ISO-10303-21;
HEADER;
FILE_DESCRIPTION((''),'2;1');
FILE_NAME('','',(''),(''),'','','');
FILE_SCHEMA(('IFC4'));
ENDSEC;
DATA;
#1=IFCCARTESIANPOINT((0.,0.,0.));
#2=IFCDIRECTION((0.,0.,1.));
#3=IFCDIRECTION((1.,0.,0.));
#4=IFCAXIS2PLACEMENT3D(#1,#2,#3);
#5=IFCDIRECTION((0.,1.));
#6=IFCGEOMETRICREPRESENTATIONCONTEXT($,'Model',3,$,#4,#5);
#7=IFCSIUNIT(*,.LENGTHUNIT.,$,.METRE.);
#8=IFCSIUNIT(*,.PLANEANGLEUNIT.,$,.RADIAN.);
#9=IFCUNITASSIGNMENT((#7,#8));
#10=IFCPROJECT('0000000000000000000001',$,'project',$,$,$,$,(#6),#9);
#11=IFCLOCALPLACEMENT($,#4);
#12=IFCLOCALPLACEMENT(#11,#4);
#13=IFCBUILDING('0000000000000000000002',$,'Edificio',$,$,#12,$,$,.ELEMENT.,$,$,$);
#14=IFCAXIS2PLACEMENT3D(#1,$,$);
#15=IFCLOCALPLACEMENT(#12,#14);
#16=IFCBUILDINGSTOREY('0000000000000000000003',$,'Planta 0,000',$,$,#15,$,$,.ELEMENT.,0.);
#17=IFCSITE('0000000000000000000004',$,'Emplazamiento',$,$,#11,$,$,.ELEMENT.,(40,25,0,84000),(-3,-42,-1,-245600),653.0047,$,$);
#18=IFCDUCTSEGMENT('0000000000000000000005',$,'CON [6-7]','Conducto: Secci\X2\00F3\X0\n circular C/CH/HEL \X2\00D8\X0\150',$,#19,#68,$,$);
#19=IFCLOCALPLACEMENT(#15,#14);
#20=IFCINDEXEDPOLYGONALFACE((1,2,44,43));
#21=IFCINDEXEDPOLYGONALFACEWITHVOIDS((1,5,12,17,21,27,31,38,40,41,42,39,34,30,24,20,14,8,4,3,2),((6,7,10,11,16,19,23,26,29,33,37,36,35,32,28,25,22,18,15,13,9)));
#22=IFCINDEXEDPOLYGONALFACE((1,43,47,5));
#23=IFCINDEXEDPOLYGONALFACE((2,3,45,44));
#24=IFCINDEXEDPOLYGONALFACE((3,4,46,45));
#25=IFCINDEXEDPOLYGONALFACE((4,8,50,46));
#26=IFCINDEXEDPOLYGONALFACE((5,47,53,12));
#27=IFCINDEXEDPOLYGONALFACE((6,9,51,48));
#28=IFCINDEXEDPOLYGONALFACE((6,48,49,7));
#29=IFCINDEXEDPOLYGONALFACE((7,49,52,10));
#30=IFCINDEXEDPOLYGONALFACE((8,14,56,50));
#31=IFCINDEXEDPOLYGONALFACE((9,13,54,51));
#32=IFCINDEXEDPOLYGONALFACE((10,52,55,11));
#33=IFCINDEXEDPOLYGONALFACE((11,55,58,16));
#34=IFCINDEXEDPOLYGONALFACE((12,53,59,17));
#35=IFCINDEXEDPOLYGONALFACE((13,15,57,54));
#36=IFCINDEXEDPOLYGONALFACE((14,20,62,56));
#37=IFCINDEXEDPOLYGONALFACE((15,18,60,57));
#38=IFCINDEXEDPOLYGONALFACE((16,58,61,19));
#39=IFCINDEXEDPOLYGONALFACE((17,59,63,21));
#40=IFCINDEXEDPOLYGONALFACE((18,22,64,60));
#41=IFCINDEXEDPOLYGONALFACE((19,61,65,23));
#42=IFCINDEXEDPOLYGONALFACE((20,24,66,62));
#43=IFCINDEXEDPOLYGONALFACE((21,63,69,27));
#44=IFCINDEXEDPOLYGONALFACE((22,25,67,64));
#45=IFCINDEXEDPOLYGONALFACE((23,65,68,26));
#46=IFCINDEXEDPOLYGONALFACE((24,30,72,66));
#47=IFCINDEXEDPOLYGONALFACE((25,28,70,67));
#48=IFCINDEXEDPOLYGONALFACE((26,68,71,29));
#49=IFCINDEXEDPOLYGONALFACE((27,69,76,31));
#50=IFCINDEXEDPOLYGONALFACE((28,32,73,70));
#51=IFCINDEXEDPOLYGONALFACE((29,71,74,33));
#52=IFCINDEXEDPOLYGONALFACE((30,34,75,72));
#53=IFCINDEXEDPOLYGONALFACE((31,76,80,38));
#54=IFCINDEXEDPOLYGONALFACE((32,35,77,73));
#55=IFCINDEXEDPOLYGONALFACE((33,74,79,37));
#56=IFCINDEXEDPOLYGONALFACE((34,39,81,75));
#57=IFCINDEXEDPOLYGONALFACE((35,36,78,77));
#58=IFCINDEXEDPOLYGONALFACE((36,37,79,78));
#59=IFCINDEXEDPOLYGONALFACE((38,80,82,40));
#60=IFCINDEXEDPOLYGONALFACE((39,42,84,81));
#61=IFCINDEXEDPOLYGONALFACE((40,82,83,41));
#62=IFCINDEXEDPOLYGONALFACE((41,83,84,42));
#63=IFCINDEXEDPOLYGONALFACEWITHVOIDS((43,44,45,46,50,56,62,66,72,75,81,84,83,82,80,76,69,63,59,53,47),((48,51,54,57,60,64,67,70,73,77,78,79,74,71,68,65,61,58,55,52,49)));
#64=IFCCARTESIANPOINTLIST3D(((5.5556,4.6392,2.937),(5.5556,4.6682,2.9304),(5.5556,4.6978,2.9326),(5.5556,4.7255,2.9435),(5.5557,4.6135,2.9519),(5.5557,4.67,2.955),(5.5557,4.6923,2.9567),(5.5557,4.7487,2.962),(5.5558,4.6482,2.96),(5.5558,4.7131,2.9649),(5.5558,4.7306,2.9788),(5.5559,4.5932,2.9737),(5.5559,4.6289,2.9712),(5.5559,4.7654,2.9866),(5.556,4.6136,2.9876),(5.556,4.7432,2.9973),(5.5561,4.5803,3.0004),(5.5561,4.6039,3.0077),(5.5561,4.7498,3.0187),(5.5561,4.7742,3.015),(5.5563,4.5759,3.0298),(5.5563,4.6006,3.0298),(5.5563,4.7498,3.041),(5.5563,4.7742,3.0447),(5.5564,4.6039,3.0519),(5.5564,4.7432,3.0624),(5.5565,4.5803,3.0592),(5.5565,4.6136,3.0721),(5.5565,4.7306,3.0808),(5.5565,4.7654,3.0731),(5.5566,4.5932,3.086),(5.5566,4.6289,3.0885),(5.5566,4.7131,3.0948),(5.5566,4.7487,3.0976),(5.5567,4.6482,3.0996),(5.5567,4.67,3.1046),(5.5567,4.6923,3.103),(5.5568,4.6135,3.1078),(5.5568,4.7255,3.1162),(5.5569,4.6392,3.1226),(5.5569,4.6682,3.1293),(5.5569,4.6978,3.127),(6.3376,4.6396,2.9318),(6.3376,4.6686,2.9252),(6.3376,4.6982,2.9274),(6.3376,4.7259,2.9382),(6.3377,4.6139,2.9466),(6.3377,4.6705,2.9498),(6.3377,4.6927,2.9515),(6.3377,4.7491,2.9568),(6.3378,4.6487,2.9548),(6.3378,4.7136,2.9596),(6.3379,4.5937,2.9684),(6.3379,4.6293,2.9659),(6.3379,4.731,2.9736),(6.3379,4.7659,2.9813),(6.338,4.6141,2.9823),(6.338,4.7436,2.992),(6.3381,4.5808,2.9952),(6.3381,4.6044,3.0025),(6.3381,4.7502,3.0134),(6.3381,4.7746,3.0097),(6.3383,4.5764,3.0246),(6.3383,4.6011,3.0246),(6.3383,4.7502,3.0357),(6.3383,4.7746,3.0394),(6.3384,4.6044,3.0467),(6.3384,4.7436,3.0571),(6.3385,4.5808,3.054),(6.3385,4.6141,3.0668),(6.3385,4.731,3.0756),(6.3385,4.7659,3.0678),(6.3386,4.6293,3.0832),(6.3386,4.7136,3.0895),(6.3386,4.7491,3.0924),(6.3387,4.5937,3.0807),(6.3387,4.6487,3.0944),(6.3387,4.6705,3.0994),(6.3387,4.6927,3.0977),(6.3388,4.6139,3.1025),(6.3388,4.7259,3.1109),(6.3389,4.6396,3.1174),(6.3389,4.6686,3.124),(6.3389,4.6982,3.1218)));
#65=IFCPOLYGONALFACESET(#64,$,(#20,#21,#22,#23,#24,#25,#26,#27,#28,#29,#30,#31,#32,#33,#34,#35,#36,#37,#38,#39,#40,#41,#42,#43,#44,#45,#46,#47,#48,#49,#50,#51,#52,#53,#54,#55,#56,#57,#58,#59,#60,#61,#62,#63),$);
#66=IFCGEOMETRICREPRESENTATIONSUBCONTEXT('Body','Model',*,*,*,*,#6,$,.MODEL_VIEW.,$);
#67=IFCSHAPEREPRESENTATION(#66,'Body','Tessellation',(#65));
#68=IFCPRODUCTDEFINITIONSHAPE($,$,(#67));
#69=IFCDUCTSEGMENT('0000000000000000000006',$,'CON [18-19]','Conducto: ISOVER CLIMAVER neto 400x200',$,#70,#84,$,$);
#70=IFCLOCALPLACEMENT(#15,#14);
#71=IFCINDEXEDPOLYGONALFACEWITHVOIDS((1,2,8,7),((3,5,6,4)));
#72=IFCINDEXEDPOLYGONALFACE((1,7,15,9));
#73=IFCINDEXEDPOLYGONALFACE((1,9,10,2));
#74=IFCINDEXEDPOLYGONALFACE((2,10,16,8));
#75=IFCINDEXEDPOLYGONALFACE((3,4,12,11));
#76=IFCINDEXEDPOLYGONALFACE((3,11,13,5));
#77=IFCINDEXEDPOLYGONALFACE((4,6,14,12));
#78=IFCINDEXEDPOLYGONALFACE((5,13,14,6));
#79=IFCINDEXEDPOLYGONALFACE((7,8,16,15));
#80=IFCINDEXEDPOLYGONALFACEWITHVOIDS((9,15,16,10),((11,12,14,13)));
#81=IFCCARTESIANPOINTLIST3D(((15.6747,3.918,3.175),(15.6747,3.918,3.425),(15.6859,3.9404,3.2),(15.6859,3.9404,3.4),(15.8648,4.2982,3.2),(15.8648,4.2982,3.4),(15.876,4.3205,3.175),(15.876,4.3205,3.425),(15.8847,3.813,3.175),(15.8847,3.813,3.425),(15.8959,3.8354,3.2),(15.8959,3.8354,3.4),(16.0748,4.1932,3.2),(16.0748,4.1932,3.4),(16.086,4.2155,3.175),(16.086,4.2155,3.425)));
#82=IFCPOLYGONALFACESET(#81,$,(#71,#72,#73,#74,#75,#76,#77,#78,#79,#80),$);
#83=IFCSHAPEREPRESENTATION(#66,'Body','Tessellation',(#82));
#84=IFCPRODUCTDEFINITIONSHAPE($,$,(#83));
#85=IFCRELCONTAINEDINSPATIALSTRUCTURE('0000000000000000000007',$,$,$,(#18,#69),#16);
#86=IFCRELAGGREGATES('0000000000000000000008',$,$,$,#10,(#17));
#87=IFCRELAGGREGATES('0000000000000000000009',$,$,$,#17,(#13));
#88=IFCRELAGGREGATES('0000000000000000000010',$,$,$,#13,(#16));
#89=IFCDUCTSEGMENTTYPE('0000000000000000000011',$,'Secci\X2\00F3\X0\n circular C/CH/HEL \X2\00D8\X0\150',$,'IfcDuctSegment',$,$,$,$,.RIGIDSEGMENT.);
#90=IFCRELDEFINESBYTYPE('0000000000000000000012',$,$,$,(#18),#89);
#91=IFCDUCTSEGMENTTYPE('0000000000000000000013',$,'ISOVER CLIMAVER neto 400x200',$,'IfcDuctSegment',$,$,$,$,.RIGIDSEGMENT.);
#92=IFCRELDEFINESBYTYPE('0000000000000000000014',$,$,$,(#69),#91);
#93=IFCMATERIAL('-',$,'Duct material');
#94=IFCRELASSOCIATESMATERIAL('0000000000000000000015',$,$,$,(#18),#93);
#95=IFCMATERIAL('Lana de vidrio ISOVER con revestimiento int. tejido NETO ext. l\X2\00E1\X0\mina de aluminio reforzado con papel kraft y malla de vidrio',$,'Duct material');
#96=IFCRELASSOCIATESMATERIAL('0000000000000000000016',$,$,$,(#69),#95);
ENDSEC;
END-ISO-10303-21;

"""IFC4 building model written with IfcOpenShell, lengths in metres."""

from ifc_helpers import new_model, si_unit, direction, frame, origin, origin_with_axes, origin_2d_with_axis, place, context, subcontext, project, spatial, hollow_rectangle, hollow_circle, extrude, material, type_object, element, save


model = new_model("IFC4")

# Units and contexts
model_context = context("Model", 3, world=origin_with_axes(), true_north=direction((0.0, 1.0)))
body_context = subcontext(model_context, "Body", "Model", "MODEL_VIEW")
ifc_project = project(units=[si_unit("LENGTHUNIT", "METRE"), si_unit("PLANEANGLEUNIT", "RADIAN")], contexts=[model_context])

# Site, building, storey
site_placement = place(None, origin_with_axes())
site = spatial("IfcSite", under=ifc_project, at=site_placement, Name="Emplazamiento", CompositionType="ELEMENT", RefLatitude=(40, 25, 0, 84000), RefLongitude=(-3, -42, -1, -245600), RefElevation=653.0047)
building_placement = place(site_placement, origin_with_axes())
building = spatial("IfcBuilding", under=site, at=building_placement, Name="Edificio", CompositionType="ELEMENT")
storey_placement = place(building_placement, origin())
storey = spatial("IfcBuildingStorey", under=building, at=storey_placement, Name="Planta 0,000", CompositionType="ELEMENT", Elevation=0.0)

# Shared definitions
ifc_material_1 = material(Name="-", Category="Duct material")

# Shared definitions
ifc_material_2 = material(Name="Lana de vidrio ISOVER con revestimiento int. tejido NETO ext. lámina de aluminio reforzado con papel kraft y malla de vidrio", Category="Duct material")

# Duct segment
duct_segment_type_1 = type_object("IfcDuctSegmentType", Name="Sección circular C/CH/HEL Ø150", ApplicableOccurrence="IfcDuctSegment", PredefinedType="RIGIDSEGMENT")
duct_segment_1_placement = place(storey_placement, origin_with_axes())
element("IfcDuctSegment", 1, at=duct_segment_1_placement, inside=storey, type_object=duct_segment_type_1, material=ifc_material_1, Name="CON [6-7]", Description="Conducto: Sección circular C/CH/HEL Ø150", context=body_context, shape_type="SweptSolid", body=[
    extrude(hollow_circle(Radius=0.0997, WallThickness=0.0247, at=origin_2d_with_axis()), frame((6.3382, 4.6761, 3.0246), z_axis=(-0.999977, -0.000565, 0.006729), x_axis=(0.000565, -1.0, 0.0)), (0.0, 0.0, 1.0), 0.782),
])

# Duct segment
duct_segment_type_2 = type_object("IfcDuctSegmentType", Name="ISOVER CLIMAVER neto 400x200", ApplicableOccurrence="IfcDuctSegment", PredefinedType="RIGIDSEGMENT")
duct_segment_2_placement = place(storey_placement, origin_with_axes())
element("IfcDuctSegment", 2, at=duct_segment_2_placement, inside=storey, type_object=duct_segment_type_2, material=ifc_material_2, Name="CON [18-19]", Description="Conducto: ISOVER CLIMAVER neto 400x200", context=body_context, shape_type="SweptSolid", body=[
    extrude(hollow_rectangle(XDim=0.45, YDim=0.25, WallThickness=0.025, at=origin_2d_with_axis()), frame((15.9853, 4.0143, 3.3), z_axis=(-0.894427, 0.447214, 0.0), x_axis=(-0.447214, -0.894427, 0.0)), (0.0, 0.0, 1.0), 0.2348),
])

save(model, "model.ifc")
